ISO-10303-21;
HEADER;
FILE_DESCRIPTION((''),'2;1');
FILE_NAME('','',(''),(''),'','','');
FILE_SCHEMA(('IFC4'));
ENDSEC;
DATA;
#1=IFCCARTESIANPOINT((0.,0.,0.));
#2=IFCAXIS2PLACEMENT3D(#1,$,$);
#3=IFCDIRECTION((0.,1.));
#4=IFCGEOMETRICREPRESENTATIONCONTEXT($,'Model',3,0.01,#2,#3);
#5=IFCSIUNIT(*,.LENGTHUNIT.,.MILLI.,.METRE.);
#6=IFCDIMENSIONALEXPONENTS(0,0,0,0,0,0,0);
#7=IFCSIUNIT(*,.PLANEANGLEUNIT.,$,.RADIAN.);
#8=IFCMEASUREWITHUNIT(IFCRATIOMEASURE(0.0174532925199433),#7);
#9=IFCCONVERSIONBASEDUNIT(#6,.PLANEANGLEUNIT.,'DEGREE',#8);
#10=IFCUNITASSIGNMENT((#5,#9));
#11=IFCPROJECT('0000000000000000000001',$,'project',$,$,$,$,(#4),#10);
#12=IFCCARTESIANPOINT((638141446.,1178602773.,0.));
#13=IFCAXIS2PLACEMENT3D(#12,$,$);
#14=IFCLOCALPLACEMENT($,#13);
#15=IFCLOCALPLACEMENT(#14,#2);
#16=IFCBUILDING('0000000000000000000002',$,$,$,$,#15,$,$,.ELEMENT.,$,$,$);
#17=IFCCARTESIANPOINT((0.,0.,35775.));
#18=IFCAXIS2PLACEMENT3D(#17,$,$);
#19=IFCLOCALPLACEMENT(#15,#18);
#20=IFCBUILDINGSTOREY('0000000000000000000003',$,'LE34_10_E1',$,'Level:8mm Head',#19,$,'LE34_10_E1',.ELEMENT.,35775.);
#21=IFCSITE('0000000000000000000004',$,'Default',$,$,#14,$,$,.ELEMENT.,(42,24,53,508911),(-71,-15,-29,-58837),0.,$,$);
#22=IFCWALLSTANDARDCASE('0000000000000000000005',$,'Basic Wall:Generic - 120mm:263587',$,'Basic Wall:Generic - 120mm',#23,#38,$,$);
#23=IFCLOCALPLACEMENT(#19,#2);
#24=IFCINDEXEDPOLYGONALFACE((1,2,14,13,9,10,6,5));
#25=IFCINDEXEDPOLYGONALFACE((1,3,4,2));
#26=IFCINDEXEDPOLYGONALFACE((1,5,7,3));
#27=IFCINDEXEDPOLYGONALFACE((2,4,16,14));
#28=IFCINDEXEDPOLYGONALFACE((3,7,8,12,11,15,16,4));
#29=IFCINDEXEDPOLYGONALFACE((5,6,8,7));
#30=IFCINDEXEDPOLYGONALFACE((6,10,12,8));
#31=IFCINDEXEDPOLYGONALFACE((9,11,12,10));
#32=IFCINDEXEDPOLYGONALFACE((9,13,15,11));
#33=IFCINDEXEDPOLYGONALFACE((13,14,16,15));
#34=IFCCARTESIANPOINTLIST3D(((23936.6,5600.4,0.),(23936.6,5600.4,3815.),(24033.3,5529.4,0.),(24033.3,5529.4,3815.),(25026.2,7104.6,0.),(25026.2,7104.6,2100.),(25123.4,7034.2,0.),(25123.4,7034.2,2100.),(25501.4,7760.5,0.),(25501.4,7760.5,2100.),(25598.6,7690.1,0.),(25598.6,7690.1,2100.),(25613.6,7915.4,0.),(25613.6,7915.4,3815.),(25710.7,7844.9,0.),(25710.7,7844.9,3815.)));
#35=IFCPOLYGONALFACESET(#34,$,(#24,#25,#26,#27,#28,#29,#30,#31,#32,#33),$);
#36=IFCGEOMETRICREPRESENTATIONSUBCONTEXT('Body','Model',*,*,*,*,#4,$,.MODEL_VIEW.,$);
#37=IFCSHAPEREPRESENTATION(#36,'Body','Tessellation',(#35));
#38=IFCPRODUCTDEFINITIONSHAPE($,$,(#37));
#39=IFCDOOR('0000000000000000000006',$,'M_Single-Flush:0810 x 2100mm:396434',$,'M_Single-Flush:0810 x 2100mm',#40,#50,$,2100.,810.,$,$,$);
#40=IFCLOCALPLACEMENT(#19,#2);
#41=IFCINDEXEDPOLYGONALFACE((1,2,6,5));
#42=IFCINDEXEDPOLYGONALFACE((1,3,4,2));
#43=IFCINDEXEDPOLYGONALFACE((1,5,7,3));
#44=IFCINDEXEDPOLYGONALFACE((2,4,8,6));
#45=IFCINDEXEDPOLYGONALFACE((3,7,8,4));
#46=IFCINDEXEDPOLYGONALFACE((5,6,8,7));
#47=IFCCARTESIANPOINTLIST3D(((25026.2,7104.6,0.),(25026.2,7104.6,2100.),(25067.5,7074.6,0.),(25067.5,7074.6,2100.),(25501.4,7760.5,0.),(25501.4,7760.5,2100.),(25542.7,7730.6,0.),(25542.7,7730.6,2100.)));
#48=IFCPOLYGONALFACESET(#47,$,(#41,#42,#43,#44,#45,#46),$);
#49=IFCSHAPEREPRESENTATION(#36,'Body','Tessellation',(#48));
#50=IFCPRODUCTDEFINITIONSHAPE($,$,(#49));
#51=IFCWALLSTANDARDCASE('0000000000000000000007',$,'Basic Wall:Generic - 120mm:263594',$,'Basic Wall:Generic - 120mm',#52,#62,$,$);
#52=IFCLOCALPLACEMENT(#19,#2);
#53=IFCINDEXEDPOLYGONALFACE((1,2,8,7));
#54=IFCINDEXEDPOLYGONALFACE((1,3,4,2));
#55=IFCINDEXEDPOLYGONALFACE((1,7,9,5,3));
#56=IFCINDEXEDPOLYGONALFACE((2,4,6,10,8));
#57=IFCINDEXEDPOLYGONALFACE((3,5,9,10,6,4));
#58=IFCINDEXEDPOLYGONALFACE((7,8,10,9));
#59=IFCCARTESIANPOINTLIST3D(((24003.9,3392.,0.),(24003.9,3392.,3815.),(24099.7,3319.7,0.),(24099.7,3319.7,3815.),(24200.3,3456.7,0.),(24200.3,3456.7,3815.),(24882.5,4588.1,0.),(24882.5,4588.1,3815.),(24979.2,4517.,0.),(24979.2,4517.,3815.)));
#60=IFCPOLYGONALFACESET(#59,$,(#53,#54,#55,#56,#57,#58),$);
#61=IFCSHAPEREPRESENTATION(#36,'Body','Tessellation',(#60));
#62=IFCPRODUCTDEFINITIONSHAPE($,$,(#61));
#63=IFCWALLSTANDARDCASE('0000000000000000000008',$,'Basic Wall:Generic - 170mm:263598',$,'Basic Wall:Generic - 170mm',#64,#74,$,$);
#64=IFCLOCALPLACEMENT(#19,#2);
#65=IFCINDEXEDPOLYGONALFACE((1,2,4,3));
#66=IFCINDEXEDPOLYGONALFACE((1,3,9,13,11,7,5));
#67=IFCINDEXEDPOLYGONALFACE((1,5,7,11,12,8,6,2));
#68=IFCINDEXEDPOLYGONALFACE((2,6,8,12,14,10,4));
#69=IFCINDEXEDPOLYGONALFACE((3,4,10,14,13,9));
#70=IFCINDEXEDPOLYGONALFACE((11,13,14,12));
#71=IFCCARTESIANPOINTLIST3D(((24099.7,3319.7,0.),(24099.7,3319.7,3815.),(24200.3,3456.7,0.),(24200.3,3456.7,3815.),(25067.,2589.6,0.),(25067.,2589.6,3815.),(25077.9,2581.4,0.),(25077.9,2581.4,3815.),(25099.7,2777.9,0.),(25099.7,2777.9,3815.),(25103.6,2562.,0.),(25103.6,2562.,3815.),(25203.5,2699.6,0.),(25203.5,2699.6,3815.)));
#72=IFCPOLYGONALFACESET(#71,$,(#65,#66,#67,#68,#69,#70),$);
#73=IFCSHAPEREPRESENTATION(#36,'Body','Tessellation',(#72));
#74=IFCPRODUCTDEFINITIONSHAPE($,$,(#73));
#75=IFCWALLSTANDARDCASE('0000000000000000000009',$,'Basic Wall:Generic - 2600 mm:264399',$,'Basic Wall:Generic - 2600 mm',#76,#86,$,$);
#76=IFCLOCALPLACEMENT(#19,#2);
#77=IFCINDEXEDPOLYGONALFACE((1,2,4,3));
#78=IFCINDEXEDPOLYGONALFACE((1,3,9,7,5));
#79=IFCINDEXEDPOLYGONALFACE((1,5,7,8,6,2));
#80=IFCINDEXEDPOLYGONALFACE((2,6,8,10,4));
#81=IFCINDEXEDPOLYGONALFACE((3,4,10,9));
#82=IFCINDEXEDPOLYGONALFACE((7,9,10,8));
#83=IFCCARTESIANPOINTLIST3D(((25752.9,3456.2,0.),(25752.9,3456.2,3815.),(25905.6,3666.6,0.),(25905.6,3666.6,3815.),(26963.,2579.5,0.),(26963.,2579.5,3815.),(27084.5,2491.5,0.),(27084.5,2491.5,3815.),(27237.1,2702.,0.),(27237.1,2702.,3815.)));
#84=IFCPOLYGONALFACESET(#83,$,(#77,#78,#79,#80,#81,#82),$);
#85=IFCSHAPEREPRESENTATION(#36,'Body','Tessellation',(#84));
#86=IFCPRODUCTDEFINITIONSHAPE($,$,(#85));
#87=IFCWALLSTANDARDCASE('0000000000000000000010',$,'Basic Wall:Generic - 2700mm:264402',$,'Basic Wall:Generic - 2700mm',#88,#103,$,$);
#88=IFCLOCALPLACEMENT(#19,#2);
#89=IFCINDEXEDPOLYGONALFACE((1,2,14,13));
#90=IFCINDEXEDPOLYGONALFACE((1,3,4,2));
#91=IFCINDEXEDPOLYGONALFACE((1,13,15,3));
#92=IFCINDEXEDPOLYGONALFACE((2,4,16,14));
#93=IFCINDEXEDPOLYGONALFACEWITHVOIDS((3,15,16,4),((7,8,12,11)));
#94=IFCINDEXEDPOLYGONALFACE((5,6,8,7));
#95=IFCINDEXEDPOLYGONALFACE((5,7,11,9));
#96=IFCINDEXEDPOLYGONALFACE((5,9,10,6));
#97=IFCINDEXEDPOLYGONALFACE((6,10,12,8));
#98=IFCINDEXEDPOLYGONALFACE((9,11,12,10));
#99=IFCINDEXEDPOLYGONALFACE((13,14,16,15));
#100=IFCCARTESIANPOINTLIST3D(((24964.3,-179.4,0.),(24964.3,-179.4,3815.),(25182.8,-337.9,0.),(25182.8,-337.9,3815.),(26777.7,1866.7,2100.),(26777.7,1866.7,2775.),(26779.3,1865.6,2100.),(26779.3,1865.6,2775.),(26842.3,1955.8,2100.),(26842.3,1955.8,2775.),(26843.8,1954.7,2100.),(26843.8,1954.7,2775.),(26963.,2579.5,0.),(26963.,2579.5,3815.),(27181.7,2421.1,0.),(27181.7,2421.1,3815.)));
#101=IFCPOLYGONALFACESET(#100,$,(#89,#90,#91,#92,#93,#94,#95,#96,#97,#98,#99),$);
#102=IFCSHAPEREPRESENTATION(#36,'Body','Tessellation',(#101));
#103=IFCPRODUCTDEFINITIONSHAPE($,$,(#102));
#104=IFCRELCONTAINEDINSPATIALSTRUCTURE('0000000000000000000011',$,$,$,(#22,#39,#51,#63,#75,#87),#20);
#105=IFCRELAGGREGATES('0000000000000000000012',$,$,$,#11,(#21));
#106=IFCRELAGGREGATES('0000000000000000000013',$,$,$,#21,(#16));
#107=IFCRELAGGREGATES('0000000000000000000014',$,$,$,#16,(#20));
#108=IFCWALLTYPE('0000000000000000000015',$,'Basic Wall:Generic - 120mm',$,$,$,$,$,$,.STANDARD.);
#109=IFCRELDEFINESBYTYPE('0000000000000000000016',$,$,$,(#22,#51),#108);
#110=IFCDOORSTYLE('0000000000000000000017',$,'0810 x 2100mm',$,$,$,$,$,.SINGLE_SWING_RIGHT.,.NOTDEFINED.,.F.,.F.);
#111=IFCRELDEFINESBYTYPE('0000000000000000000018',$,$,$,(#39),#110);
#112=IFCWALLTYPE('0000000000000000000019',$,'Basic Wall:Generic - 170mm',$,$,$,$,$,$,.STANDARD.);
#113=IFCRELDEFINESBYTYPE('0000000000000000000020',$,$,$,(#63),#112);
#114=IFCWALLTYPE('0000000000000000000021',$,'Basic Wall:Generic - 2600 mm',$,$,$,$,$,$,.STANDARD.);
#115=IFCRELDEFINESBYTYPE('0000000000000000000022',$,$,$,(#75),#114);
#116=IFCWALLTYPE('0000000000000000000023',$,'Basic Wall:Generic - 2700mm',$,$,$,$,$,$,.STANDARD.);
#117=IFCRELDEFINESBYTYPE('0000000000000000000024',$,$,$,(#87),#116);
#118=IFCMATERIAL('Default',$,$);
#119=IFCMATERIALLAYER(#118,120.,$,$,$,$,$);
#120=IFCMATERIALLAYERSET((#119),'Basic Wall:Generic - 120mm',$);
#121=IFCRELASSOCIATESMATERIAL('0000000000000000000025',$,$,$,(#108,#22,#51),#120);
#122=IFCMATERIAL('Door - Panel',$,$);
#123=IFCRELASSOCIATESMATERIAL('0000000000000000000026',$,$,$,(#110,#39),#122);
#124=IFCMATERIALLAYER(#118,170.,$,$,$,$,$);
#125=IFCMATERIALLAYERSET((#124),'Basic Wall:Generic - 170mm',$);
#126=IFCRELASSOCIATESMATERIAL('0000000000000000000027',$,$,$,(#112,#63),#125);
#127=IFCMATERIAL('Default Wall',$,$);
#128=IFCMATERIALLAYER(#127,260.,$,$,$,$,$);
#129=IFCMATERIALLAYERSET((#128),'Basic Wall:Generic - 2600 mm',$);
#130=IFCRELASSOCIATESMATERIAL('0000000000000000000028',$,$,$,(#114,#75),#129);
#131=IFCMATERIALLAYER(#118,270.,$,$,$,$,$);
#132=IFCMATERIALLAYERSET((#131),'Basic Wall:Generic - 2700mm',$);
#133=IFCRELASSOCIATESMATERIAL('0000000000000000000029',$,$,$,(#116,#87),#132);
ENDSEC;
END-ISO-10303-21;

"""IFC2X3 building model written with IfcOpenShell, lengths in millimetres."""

from ifc_helpers import new_model, entity, si_unit, converted_unit, direction, frame, frame_2d, origin, origin_2d_with_axis, place, context, subcontext, project, spatial, polyline, rectangle, outline, extrude, source, transform, mapped, material, layer, layer_set, layer_usage, type_object, type_shapes, element, fill, save


model = new_model("IFC2X3")

# Units and contexts
model_context = context("Model", 3, precision=0.01, world=origin(), true_north=direction((0.0, 1.0)))
body_context = subcontext(model_context, "Body", "Model", "MODEL_VIEW")
ifc_project = project(units=[si_unit("LENGTHUNIT", "METRE", prefix="MILLI"), converted_unit("PLANEANGLEUNIT", "DEGREE", entity("IfcRatioMeasure", 0.0174532925199433), si_unit("PLANEANGLEUNIT", "RADIAN"), dimensions=[0, 0, 0, 0, 0, 0, 0])], contexts=[model_context])

# Site, building, storey
site_placement = place(None, frame((638141446.0, 1178602773.0, 0.0)))
site = spatial("IfcSite", under=ifc_project, at=site_placement, Name="Default", CompositionType="ELEMENT", RefLatitude=(42, 24, 53, 508911), RefLongitude=(-71, -15, -29, -58837), RefElevation=0.0)
building_placement = place(site_placement, origin())
building = spatial("IfcBuilding", under=site, at=building_placement, CompositionType="ELEMENT")
storey_placement = place(building_placement, frame((0.0, 0.0, 35775.0)))
storey = spatial("IfcBuildingStorey", under=building, at=storey_placement, Name="LE34_10_E1", ObjectType="Level:8mm Head", LongName="LE34_10_E1", CompositionType="ELEMENT", Elevation=35775.0)

# Shared definitions
ifc_material_1 = material(Name="Default")

# Shared definitions
ifc_material_2 = material(Name="Door - Panel")

# Wall, opening, door
ifc_layer_1 = layer(ifc_material_1, 120.0)
ifc_layer_set_1 = layer_set([ifc_layer_1], Name="Basic Wall:Generic - 120mm")
ifc_layer_usage_1 = layer_usage(ifc_layer_set_1, "AXIS2", "NEGATIVE", 60.0)
wall_type_1 = type_object("IfcWallType", Name="Basic Wall:Generic - 120mm", PredefinedType="STANDARD", material=ifc_layer_set_1)
wall_1_placement = place(storey_placement, frame((23984.7, 5564.6, 0.0), z_axis=(0.0, 0.0, 1.0), x_axis=(0.586669, 0.809827, 0.0)))
wall_1 = element("IfcWallStandardCase", 1, at=wall_1_placement, inside=storey, type_object=wall_type_1, material=ifc_layer_usage_1, Name="Basic Wall:Generic - 120mm:263587", ObjectType="Basic Wall:Generic - 120mm", context=body_context, shape_type="SweptSolid", body=[
    extrude(outline(polyline([(0.0, -60.0), (2859.3, -60.0), (2859.3, 60.0), (0.8, 60.0), (0.0, -60.0)])), origin(), (0.0, 0.0, 1.0), 3815.0),
])
opening_1_placement = place(wall_1_placement, frame((1858.1, -60.0, 0.0)))
opening_1 = element("IfcOpeningElement", 2, at=opening_1_placement, cuts=wall_1, ObjectType="Opening", context=body_context, shape_type="SweptSolid", body=[
    extrude(rectangle(XDim=810.0, YDim=2100.0, at=frame_2d((1050.0, 405.0), x_axis=(0.0, 1.0))), frame((0.0, 0.0, 0.0), z_axis=(0.0, 1.0, 0.0), x_axis=(0.0, 0.0, 1.0)), (0.0, 0.0, 1.0), 120.0),
])
door_style_1 = type_object("IfcDoorStyle", Name="0810 x 2100mm", ConstructionType="NOTDEFINED", OperationType="SINGLE_SWING_RIGHT", ParameterTakesPrecedence=False, Sizeable=False, material=ifc_material_2)
shared_shape_1 = source(origin(), body_context, "Body", "SweptSolid", [
    extrude(rectangle(XDim=51.0, YDim=810.0, at=origin_2d_with_axis()), frame((405.0, 94.5, 0.0), z_axis=(0.0, 0.0, 1.0), x_axis=(0.0, 1.0, 0.0)), (0.0, 0.0, 1.0), 2100.0),
])
type_shapes(door_style_1, [shared_shape_1])
door_1_placement = place(opening_1_placement, origin())
door_1 = element("IfcDoor", 3, at=door_1_placement, inside=storey, type_object=door_style_1, material=ifc_material_2, Name="M_Single-Flush:0810 x 2100mm:396434", ObjectType="M_Single-Flush:0810 x 2100mm", OverallHeight=2100.0, OverallWidth=810.0, context=body_context, shape_type="MappedRepresentation", body=[
    mapped(shared_shape_1, transform((0.0, 0.0, 0.0), scale=1.0)),
])
fill(opening_1, door_1)

# Walls
ifc_layer_usage_2 = layer_usage(ifc_layer_set_1, "AXIS2", "NEGATIVE", 60.0)
wall_2_placement = place(storey_placement, frame((24051.3, 3355.2, 0.0), z_axis=(0.0, 0.0, 1.0), x_axis=(0.592029, 0.805916, 0.0)))
element("IfcWallStandardCase", 4, at=wall_2_placement, inside=storey, type_object=wall_type_1, material=ifc_layer_usage_2, Name="Basic Wall:Generic - 120mm:263594", ObjectType="Basic Wall:Generic - 120mm", context=body_context, shape_type="SweptSolid", body=[
    extrude(outline(polyline([(1485.7, -60.0), (1485.7, 60.0), (1.6, 60.0), (0.0, -60.0), (170.0, -60.0), (1485.7, -60.0)])), origin(), (0.0, 0.0, 1.0), 3815.0),
])
ifc_layer_2 = layer(ifc_material_1, 170.0)
ifc_layer_set_2 = layer_set([ifc_layer_2], Name="Basic Wall:Generic - 170mm")
ifc_layer_usage_3 = layer_usage(ifc_layer_set_2, "AXIS2", "NEGATIVE", 85.0)
wall_type_2 = type_object("IfcWallType", Name="Basic Wall:Generic - 170mm", PredefinedType="STANDARD", material=ifc_layer_set_2)
wall_3_placement = place(storey_placement, frame((25154.8, 2629.8, 0.0), z_axis=(0.0, 0.0, 1.0), x_axis=(-0.798162, 0.602443, 0.0)))
element("IfcWallStandardCase", 5, at=wall_3_placement, inside=storey, type_object=wall_type_2, material=ifc_layer_usage_3, Name="Basic Wall:Generic - 170mm:263598", ObjectType="Basic Wall:Generic - 170mm", context=body_context, shape_type="SweptSolid", body=[
    extrude(outline(polyline([(1260.0, -85.0), (1257.8, 85.0), (45.9, 85.0), (32.2, 85.0), (0.0, 85.0), (3.2, -85.0), (133.2, -85.0), (1260.0, -85.0)])), origin(), (0.0, 0.0, 1.0), 3815.0),
])
ifc_material_3 = material(Name="Default Wall")
ifc_layer_3 = layer(ifc_material_3, 260.0)
ifc_layer_set_3 = layer_set([ifc_layer_3], Name="Basic Wall:Generic - 2600 mm")
ifc_layer_usage_4 = layer_usage(ifc_layer_set_3, "AXIS2", "NEGATIVE", 130.0)
wall_type_3 = type_object("IfcWallType", Name="Basic Wall:Generic - 2600 mm", PredefinedType="STANDARD", material=ifc_layer_set_3)
wall_4_placement = place(storey_placement, frame((25829.1, 3561.5, 0.0), z_axis=(0.0, 0.0, 1.0), x_axis=(0.809804, -0.5867, 0.0)))
element("IfcWallStandardCase", 6, at=wall_4_placement, inside=storey, type_object=wall_type_3, material=ifc_layer_usage_4, Name="Basic Wall:Generic - 2600 mm:264399", ObjectType="Basic Wall:Generic - 2600 mm", context=body_context, shape_type="SweptSolid", body=[
    extrude(outline(polyline([(1644.4, -130.0), (1644.4, 130.0), (0.3, 130.0), (0.0, -130.0), (1494.4, -130.0), (1644.4, -130.0)])), origin(), (0.0, 0.0, 1.0), 3815.0),
])

# Wall, opening
ifc_layer_4 = layer(ifc_material_1, 270.0)
ifc_layer_set_4 = layer_set([ifc_layer_4], Name="Basic Wall:Generic - 2700mm")
ifc_layer_usage_5 = layer_usage(ifc_layer_set_4, "AXIS2", "NEGATIVE", 135.0)
wall_type_4 = type_object("IfcWallType", Name="Basic Wall:Generic - 2700mm", PredefinedType="STANDARD", material=ifc_layer_set_4)
wall_5_placement = place(storey_placement, frame((25073.5, -258.7, 0.0), z_axis=(0.0, 0.0, 1.0), x_axis=(0.5867, 0.809804, 0.0)))
wall_5 = element("IfcWallStandardCase", 7, at=wall_5_placement, inside=storey, type_object=wall_type_4, material=ifc_layer_usage_5, Name="Basic Wall:Generic - 2700mm:264402", ObjectType="Basic Wall:Generic - 2700mm", context=body_context, shape_type="SweptSolid", body=[
    extrude(outline(polyline([(3406.9, -135.0), (3406.9, -15.0), (3406.9, 135.0), (2422.5, 135.0), (2302.5, 135.0), (0.2, 135.0), (0.0, -135.0), (2721.0, -135.0), (2831.0, -135.0), (3406.9, -135.0)])), origin(), (0.0, 0.0, 1.0), 3815.0),
])
opening_2_placement = place(wall_5_placement, origin())
element("IfcOpeningElement", 8, at=opening_2_placement, cuts=wall_5, ObjectType="Opening", context=body_context, shape_type="SweptSolid", body=[
    extrude(rectangle(XDim=675.0, YDim=110.0, at=frame_2d((0.0, 0.0), x_axis=(0.0, 1.0))), frame((2776.0, -693.1, 2437.5), z_axis=(0.0, 1.0, 0.0), x_axis=(-1.0, 0.0, 0.0)), (0.0, 0.0, 1.0), 560.0),
])

save(model, "model.ifc")
